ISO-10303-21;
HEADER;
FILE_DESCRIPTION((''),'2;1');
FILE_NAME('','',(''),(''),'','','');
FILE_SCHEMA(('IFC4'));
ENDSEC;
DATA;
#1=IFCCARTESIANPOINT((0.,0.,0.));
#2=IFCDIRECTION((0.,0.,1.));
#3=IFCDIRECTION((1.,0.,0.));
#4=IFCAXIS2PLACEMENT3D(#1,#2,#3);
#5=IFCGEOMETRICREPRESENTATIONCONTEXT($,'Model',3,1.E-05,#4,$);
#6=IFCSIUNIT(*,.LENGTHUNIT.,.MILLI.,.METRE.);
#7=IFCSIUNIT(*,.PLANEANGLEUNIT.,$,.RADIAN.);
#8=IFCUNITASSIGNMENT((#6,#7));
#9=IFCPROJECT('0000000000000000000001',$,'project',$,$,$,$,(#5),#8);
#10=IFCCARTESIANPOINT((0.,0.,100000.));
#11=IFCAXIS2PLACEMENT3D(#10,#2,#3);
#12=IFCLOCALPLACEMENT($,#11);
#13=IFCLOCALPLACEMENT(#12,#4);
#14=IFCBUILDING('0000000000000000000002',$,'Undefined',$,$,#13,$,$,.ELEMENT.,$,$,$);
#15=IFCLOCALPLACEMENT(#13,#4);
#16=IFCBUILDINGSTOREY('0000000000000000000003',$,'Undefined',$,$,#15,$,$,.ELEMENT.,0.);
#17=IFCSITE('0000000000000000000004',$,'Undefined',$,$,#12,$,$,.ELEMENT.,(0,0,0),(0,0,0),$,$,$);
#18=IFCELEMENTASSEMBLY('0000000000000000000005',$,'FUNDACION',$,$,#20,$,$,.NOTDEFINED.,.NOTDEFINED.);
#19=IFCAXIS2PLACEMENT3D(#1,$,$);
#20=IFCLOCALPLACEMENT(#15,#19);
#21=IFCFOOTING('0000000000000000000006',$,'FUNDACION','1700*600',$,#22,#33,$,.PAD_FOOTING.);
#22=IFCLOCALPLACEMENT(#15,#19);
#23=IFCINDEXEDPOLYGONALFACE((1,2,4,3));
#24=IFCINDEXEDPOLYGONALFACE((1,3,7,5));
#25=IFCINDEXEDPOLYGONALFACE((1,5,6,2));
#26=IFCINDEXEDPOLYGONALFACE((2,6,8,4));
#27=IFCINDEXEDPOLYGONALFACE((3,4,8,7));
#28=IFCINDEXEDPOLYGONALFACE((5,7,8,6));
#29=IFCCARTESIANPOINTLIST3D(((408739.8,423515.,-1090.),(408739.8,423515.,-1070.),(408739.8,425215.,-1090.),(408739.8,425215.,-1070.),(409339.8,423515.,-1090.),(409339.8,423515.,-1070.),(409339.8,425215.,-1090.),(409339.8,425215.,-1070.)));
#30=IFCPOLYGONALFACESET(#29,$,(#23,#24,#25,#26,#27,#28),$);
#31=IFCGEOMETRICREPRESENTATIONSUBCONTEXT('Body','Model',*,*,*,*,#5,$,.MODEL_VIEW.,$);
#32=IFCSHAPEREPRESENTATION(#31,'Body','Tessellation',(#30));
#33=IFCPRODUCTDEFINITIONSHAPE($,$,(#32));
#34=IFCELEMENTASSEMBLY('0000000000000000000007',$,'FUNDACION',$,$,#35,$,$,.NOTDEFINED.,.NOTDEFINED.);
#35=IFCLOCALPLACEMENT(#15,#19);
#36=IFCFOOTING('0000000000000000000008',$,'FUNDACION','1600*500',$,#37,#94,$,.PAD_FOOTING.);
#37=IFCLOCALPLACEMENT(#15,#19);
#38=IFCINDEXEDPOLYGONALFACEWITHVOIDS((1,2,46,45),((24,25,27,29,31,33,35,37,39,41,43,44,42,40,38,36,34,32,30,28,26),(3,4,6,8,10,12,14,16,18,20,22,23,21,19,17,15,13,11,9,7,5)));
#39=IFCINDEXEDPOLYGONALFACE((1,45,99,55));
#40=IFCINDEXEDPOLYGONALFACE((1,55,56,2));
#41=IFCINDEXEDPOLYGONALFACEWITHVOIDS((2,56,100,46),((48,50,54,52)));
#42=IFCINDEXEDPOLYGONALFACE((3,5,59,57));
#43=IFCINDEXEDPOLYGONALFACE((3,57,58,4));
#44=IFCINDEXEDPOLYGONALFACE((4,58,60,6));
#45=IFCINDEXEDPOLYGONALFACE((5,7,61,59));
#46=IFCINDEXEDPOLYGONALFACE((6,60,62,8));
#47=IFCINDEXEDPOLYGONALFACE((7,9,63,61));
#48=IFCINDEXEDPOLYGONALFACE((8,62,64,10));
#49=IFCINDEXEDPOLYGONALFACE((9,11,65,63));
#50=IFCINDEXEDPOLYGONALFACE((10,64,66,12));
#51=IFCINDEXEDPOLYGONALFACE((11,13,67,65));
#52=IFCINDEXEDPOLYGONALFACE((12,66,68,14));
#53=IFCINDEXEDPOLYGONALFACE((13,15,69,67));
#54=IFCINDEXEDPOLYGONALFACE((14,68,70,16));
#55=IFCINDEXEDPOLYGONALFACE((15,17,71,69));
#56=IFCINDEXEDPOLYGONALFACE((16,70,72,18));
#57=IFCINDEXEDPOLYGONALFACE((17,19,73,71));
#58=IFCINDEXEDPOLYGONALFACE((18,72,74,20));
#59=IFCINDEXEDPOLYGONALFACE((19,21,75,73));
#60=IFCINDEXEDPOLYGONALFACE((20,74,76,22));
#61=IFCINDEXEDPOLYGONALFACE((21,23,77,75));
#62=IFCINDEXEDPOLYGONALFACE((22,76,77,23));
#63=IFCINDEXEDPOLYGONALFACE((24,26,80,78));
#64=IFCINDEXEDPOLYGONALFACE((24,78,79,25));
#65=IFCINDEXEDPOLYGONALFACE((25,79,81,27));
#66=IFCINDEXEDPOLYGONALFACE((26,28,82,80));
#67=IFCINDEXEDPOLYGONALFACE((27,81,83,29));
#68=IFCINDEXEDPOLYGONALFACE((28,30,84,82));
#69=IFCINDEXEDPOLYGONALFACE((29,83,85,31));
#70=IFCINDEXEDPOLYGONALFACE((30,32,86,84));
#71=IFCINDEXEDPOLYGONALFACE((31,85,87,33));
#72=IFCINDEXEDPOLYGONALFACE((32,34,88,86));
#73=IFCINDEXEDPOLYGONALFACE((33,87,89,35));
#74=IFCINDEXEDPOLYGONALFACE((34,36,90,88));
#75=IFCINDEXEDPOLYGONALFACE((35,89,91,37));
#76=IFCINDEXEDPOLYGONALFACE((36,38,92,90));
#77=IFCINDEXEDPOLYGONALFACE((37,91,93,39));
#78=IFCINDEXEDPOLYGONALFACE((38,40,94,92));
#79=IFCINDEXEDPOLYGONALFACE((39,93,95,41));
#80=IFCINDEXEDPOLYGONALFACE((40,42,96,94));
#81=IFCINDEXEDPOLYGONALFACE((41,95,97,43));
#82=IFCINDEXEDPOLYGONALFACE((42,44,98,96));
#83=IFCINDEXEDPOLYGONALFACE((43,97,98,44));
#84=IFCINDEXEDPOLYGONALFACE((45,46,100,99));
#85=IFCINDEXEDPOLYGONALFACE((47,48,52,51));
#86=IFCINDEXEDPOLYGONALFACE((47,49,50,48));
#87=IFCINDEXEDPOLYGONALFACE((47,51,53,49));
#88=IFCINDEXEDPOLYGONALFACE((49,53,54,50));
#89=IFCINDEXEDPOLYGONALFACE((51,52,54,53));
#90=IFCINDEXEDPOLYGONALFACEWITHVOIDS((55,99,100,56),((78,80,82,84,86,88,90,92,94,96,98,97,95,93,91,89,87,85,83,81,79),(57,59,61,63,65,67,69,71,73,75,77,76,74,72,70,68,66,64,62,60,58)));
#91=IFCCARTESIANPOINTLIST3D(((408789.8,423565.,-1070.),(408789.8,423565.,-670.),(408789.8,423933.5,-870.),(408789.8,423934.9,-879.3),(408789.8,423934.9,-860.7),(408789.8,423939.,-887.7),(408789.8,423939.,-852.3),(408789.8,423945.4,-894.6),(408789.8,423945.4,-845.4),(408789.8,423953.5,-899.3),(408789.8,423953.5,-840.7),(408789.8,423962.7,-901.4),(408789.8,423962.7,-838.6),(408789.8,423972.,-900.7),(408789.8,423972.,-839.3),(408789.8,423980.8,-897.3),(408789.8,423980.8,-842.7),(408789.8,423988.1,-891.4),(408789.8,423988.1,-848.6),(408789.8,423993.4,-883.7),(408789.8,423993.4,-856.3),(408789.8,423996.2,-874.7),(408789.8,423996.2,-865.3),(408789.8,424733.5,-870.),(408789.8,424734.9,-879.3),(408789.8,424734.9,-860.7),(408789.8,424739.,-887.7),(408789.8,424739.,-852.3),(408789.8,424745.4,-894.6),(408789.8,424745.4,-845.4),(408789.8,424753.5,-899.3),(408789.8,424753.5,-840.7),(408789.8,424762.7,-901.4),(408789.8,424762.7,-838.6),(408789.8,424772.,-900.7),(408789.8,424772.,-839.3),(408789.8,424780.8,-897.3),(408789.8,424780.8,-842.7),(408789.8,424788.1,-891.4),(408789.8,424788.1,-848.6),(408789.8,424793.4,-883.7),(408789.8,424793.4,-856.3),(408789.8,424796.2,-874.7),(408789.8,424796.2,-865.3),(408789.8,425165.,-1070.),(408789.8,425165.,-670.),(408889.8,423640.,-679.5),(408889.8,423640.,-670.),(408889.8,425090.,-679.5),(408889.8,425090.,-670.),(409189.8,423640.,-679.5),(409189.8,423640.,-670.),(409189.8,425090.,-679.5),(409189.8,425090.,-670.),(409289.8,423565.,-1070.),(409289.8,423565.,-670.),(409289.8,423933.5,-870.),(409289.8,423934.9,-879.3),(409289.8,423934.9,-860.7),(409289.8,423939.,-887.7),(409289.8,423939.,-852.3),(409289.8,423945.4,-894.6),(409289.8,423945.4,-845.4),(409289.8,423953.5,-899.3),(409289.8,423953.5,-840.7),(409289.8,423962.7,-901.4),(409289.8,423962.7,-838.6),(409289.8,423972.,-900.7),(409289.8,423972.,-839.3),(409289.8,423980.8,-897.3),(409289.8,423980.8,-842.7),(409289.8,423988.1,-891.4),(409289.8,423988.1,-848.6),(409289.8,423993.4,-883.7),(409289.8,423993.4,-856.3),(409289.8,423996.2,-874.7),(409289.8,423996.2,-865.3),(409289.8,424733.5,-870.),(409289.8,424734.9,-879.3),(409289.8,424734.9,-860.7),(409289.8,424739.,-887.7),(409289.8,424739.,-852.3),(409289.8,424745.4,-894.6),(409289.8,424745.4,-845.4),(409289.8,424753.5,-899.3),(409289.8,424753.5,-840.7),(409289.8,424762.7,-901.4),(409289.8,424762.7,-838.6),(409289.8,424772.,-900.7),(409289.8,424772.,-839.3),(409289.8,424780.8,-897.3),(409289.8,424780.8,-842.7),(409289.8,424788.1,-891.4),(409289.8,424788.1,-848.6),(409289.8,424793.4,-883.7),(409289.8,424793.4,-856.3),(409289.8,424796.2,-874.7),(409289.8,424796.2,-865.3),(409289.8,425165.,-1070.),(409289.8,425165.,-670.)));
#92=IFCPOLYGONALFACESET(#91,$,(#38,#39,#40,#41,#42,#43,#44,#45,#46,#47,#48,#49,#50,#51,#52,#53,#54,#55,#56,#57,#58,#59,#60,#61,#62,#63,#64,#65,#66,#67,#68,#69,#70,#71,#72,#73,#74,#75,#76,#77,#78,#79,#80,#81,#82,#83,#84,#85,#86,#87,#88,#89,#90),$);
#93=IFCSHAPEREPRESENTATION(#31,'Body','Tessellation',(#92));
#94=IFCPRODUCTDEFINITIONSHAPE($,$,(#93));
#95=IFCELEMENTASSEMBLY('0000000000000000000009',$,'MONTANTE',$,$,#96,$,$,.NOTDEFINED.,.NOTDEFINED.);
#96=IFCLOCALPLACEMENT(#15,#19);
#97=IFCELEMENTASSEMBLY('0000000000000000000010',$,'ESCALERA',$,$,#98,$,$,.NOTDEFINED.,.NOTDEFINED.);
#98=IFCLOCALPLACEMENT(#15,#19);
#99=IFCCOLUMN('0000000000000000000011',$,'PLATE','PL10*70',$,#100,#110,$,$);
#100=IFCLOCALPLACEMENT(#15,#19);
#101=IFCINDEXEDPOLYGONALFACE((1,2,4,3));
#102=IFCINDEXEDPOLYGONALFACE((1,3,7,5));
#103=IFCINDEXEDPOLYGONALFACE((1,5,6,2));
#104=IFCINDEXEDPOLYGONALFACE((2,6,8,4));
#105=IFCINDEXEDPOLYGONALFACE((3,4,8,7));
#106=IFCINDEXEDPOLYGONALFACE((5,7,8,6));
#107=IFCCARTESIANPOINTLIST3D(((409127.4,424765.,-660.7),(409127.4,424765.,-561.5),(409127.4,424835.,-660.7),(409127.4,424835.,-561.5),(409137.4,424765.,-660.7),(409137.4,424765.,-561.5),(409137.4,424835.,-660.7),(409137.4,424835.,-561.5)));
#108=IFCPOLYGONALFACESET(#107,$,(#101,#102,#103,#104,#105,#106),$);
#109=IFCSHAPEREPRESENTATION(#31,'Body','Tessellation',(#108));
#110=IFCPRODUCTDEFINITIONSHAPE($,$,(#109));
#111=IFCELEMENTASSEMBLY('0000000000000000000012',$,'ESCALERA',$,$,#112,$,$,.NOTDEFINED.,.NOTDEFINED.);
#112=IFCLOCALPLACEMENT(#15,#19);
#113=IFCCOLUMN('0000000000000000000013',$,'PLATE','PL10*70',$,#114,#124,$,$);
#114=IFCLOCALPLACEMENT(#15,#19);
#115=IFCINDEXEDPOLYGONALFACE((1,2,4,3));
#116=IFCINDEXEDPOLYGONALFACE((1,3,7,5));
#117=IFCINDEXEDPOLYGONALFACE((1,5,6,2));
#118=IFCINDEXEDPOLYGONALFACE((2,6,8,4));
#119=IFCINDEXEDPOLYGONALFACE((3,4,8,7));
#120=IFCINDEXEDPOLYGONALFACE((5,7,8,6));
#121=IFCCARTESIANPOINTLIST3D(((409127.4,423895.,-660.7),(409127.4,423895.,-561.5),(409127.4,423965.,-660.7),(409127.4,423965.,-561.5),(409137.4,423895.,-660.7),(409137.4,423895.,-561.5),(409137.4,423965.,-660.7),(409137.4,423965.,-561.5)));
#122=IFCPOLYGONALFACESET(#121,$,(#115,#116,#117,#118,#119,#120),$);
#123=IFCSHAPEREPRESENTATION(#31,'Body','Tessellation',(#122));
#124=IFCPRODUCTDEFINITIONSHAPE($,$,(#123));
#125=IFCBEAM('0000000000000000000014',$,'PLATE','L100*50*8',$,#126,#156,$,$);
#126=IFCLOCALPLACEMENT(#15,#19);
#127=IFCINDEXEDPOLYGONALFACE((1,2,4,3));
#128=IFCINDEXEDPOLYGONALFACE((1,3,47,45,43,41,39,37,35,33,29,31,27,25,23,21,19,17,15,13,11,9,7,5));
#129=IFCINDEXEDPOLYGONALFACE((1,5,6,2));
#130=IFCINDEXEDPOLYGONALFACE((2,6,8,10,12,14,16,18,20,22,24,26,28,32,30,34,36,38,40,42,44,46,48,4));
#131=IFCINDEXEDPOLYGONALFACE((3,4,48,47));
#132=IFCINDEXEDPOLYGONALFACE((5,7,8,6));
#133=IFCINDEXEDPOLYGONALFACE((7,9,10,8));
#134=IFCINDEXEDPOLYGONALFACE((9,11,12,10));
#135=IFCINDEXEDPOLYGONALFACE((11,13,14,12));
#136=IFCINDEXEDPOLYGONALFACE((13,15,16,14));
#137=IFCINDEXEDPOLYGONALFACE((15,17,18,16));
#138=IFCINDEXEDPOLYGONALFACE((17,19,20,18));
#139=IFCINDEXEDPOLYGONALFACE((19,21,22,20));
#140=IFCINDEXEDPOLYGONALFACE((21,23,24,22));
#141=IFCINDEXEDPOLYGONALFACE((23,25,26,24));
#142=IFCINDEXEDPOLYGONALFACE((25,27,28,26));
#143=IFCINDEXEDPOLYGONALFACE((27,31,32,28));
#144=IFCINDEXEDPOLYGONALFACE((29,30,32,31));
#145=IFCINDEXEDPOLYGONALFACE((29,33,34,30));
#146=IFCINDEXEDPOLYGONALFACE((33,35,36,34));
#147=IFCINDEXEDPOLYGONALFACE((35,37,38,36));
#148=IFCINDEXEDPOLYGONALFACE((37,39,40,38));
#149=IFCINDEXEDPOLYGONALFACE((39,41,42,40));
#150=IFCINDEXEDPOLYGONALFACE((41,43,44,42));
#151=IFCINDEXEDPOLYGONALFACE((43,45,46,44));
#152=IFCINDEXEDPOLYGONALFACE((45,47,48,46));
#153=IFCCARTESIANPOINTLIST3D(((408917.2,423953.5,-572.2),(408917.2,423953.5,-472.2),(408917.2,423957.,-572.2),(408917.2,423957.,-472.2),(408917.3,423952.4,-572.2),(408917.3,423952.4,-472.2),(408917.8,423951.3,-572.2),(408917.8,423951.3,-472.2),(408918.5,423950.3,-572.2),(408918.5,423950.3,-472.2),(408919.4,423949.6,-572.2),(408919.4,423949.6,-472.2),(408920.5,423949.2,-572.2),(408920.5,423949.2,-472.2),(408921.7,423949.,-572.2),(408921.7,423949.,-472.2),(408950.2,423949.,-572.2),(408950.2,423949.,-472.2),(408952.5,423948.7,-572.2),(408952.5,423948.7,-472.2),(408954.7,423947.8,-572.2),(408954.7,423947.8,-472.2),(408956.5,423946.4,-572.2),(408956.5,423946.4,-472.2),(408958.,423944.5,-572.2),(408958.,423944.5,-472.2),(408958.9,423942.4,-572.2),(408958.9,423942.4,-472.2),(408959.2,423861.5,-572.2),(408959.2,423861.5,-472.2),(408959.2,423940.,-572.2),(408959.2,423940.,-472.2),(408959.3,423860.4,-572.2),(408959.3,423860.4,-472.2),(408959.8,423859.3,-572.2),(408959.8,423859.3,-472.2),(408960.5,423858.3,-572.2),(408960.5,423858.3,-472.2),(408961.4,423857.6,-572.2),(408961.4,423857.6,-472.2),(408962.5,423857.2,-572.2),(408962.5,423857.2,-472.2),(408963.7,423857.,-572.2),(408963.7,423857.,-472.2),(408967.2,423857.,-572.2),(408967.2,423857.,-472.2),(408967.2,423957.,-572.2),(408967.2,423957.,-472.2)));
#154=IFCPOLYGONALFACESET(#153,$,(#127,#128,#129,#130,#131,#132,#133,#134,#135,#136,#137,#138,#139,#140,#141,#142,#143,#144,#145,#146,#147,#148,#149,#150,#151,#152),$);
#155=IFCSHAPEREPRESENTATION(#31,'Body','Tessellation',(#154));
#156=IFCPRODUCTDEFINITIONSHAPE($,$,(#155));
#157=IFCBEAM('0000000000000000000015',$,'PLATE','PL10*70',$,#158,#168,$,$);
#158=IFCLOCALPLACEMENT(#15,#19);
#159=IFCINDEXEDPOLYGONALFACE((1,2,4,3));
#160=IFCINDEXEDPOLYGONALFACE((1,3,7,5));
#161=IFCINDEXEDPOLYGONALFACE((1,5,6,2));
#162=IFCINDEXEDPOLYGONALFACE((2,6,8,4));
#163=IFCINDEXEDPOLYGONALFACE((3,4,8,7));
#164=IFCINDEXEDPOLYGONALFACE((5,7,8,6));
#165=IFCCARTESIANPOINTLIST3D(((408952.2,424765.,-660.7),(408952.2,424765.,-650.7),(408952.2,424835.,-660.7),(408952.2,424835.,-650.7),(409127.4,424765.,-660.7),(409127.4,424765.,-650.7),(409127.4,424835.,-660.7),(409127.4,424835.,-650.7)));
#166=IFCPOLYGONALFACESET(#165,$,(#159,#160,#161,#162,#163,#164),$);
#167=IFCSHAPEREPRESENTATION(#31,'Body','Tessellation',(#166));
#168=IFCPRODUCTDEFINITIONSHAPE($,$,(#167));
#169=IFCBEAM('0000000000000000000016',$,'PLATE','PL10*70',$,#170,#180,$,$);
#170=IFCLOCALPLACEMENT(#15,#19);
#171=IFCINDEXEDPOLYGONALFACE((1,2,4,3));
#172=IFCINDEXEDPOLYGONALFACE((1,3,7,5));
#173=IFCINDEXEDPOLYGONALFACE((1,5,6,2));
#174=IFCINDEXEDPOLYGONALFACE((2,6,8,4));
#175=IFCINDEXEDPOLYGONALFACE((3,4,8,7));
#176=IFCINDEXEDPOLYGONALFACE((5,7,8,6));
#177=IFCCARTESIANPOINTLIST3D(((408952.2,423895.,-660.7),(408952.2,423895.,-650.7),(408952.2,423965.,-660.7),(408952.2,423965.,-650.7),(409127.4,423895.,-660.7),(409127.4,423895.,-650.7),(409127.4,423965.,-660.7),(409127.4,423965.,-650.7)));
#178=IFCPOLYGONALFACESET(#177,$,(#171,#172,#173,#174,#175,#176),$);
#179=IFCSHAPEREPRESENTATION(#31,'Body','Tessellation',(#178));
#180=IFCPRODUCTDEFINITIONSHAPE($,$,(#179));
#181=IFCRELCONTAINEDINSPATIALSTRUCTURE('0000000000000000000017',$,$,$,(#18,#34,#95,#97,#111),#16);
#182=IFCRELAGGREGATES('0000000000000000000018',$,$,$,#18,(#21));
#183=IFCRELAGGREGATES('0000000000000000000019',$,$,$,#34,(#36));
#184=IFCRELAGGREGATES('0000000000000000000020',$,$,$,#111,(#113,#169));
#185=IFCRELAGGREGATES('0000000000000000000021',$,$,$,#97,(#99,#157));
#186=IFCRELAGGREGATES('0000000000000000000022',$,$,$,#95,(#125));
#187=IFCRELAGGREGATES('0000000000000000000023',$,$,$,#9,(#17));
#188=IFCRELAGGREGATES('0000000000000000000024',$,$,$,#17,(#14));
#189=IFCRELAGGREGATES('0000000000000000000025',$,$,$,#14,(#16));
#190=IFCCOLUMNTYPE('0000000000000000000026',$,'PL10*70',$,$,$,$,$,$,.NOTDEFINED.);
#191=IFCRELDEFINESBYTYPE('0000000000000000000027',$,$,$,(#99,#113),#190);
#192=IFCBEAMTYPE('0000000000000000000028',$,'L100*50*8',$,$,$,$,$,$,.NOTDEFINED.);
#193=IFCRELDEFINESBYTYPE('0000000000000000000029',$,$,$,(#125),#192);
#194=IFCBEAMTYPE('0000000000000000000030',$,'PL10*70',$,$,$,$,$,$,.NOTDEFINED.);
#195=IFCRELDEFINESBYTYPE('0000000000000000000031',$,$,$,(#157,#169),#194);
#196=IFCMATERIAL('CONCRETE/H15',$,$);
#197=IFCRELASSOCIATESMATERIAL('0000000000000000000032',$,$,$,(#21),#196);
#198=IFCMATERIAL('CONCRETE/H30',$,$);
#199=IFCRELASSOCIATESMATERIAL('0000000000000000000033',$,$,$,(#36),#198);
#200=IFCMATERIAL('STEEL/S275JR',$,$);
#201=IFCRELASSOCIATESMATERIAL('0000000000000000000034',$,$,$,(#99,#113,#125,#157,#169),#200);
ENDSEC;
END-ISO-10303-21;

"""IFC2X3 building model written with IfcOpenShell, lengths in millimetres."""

from ifc_helpers import new_model, si_unit, frame, origin_with_axes, origin_2d_with_axis, place, context, subcontext, project, spatial, polyline, rectangle, circle, l_section, outline, extrude, boolean, material, type_object, element, aggregate, save


model = new_model("IFC2X3")

# Units and contexts
model_context = context("Model", 3, precision=1e-05, world=origin_with_axes())
body_context = subcontext(model_context, "Body", "Model", "MODEL_VIEW")
ifc_project = project(units=[si_unit("LENGTHUNIT", "METRE", prefix="MILLI"), si_unit("PLANEANGLEUNIT", "RADIAN")], contexts=[model_context])

# Site, building, storey
site_placement = place(None, frame((0.0, 0.0, 100000.0), z_axis=(0.0, 0.0, 1.0), x_axis=(1.0, 0.0, 0.0)))
site = spatial("IfcSite", under=ifc_project, at=site_placement, Name="Undefined", CompositionType="ELEMENT", RefLatitude=(0, 0, 0), RefLongitude=(0, 0, 0))
building_placement = place(site_placement, origin_with_axes())
building = spatial("IfcBuilding", under=site, at=building_placement, Name="Undefined", CompositionType="ELEMENT")
storey_placement = place(building_placement, origin_with_axes())
storey = spatial("IfcBuildingStorey", under=building, at=storey_placement, Name="Undefined", CompositionType="ELEMENT", Elevation=0.0)

# Element assemblies, footings
assembly_1_placement = place(storey_placement, origin_with_axes())
assembly_1 = element("IfcElementAssembly", 1, at=assembly_1_placement, inside=storey, Name="FUNDACION", AssemblyPlace="NOTDEFINED", PredefinedType="NOTDEFINED")
ifc_material_1 = material(Name="CONCRETE/H15")
footing_1_placement = place(assembly_1_placement, frame((409039.8, 424365.0, -1090.0), z_axis=(0.0, 1.0, 0.0), x_axis=(0.0, 0.0, 1.0)))
footing_1 = element("IfcFooting", 2, at=footing_1_placement, material=ifc_material_1, Name="FUNDACION", Description="1700*600", PredefinedType="PAD_FOOTING", context=body_context, shape_type="SweptSolid", body=[
    extrude(rectangle(XDim=600.0, YDim=1700.0, at=origin_2d_with_axis()), frame((20.0, 0.0, 0.0), z_axis=(-1.0, 0.0, 0.0), x_axis=(0.0, -1.0, 0.0)), (0.0, 0.0, 1.0), 20.0),
])
aggregate(assembly_1, [footing_1])
assembly_2_placement = place(storey_placement, origin_with_axes())
assembly_2 = element("IfcElementAssembly", 3, at=assembly_2_placement, inside=storey, Name="FUNDACION", AssemblyPlace="NOTDEFINED", PredefinedType="NOTDEFINED")
ifc_material_2 = material(Name="CONCRETE/H30")
footing_2_placement = place(assembly_2_placement, frame((409039.8, 424365.0, -1070.0), z_axis=(0.0, 1.0, 0.0), x_axis=(0.0, 0.0, 1.0)))
footing_2 = element("IfcFooting", 4, at=footing_2_placement, material=ifc_material_2, Name="FUNDACION", Description="1600*500", PredefinedType="PAD_FOOTING", context=body_context, shape_type="CSG", body=[
    boolean("DIFFERENCE", boolean("DIFFERENCE", boolean("DIFFERENCE", extrude(rectangle(XDim=500.0, YDim=1600.0, at=origin_2d_with_axis()), frame((400.0, 0.0, 0.0), z_axis=(-1.0, 0.0, 0.0), x_axis=(0.0, -1.0, 0.0)), (0.0, 0.0, 1.0), 400.0), extrude(circle(Radius=31.5, at=origin_2d_with_axis()), frame((200.0, 300.0, 400.0), z_axis=(0.0, -1.0, 0.0), x_axis=(0.0, 0.0, -1.0)), (0.0, 0.0, 1.0), 600.0)), extrude(circle(Radius=31.5, at=origin_2d_with_axis()), frame((200.0, 300.0, -400.0), z_axis=(0.0, -1.0, 0.0), x_axis=(0.0, 0.0, -1.0)), (0.0, 0.0, 1.0), 600.0)), extrude(outline(polyline([(0.0, 0.0), (1450.0, 0.0), (1450.0, 300.0), (0.0, 300.0), (0.0, 0.0)])), frame((390.5, -150.0, 725.0), z_axis=(1.0, 0.0, 0.0), x_axis=(0.0, 0.0, -1.0)), (0.0, 0.0, 1.0), 19.0)),
])
aggregate(assembly_2, [footing_2])

# Element assemblies, columns
assembly_3_placement = place(storey_placement, origin_with_axes())
assembly_3 = element("IfcElementAssembly", 5, at=assembly_3_placement, inside=storey, Name="MONTANTE", AssemblyPlace="NOTDEFINED", PredefinedType="NOTDEFINED")
assembly_4_placement = place(storey_placement, origin_with_axes())
assembly_4 = element("IfcElementAssembly", 6, at=assembly_4_placement, inside=storey, Name="ESCALERA", AssemblyPlace="NOTDEFINED", PredefinedType="NOTDEFINED")
ifc_material_3 = material(Name="STEEL/S275JR")
column_type_1 = type_object("IfcColumnType", Name="PL10*70", PredefinedType="NOTDEFINED")
column_1_placement = place(assembly_4_placement, frame((409132.4, 424800.0, -660.7), z_axis=(0.0, 0.0, 1.0), x_axis=(0.0, 1.0, 0.0)))
column_1 = element("IfcColumn", 7, at=column_1_placement, type_object=column_type_1, material=ifc_material_3, Name="PLATE", Description="PL10*70", context=body_context, shape_type="SweptSolid", body=[
    extrude(rectangle(XDim=10.0, YDim=70.0, at=origin_2d_with_axis()), frame((0.0, 0.0, 99.2), z_axis=(0.0, 0.0, -1.0), x_axis=(0.0, 1.0, 0.0)), (0.0, 0.0, 1.0), 99.2),
])
assembly_5_placement = place(storey_placement, origin_with_axes())
assembly_5 = element("IfcElementAssembly", 8, at=assembly_5_placement, inside=storey, Name="ESCALERA", AssemblyPlace="NOTDEFINED", PredefinedType="NOTDEFINED")
column_2_placement = place(assembly_5_placement, frame((409132.4, 423930.0, -660.7), z_axis=(0.0, 0.0, 1.0), x_axis=(0.0, 1.0, 0.0)))
column_2 = element("IfcColumn", 9, at=column_2_placement, type_object=column_type_1, material=ifc_material_3, Name="PLATE", Description="PL10*70", context=body_context, shape_type="SweptSolid", body=[
    extrude(rectangle(XDim=10.0, YDim=70.0, at=origin_2d_with_axis()), frame((0.0, 0.0, 99.2), z_axis=(0.0, 0.0, -1.0), x_axis=(0.0, 1.0, 0.0)), (0.0, 0.0, 1.0), 99.2),
])

# Beams
beam_type_1 = type_object("IfcBeamType", Name="L100*50*8", PredefinedType="NOTDEFINED")
beam_1_placement = place(assembly_3_placement, frame((408942.2, 423907.0, -472.2), z_axis=(0.0, -1.0, 0.0), x_axis=(0.0, 0.0, -1.0)))
beam_1 = element("IfcBeam", 10, at=beam_1_placement, type_object=beam_type_1, material=ifc_material_3, Name="PLATE", Description="L100*50*8", context=body_context, shape_type="SweptSolid", body=[
    extrude(l_section(Depth=100.0, Width=50.0, Thickness=8.0, FilletRadius=9.0, EdgeRadius=4.5, at=origin_2d_with_axis()), frame((100.0, 0.0, 0.0), z_axis=(-1.0, 0.0, 0.0), x_axis=(0.0, -1.0, 0.0)), (0.0, 0.0, 1.0), 100.0),
])
beam_type_2 = type_object("IfcBeamType", Name="PL10*70", PredefinedType="NOTDEFINED")
beam_2_placement = place(assembly_4_placement, frame((408952.2, 424800.0, -655.7), z_axis=(0.0, 1.0, 0.0), x_axis=(1.0, 0.0, 0.0)))
beam_2 = element("IfcBeam", 11, at=beam_2_placement, type_object=beam_type_2, material=ifc_material_3, Name="PLATE", Description="PL10*70", context=body_context, shape_type="SweptSolid", body=[
    extrude(rectangle(XDim=10.0, YDim=70.0, at=origin_2d_with_axis()), frame((175.3, 0.0, 0.0), z_axis=(-1.0, 0.0, 0.0), x_axis=(0.0, -1.0, 0.0)), (0.0, 0.0, 1.0), 175.2),
])
beam_3_placement = place(assembly_5_placement, frame((408952.2, 423930.0, -655.7), z_axis=(0.0, 1.0, 0.0), x_axis=(1.0, 0.0, 0.0)))
beam_3 = element("IfcBeam", 12, at=beam_3_placement, type_object=beam_type_2, material=ifc_material_3, Name="PLATE", Description="PL10*70", context=body_context, shape_type="SweptSolid", body=[
    extrude(rectangle(XDim=10.0, YDim=70.0, at=origin_2d_with_axis()), frame((175.3, 0.0, 0.0), z_axis=(-1.0, 0.0, 0.0), x_axis=(0.0, -1.0, 0.0)), (0.0, 0.0, 1.0), 175.2),
])
aggregate(assembly_5, [column_2, beam_3])

aggregate(assembly_4, [column_1, beam_2])

aggregate(assembly_3, [beam_1])

save(model, "model.ifc")
